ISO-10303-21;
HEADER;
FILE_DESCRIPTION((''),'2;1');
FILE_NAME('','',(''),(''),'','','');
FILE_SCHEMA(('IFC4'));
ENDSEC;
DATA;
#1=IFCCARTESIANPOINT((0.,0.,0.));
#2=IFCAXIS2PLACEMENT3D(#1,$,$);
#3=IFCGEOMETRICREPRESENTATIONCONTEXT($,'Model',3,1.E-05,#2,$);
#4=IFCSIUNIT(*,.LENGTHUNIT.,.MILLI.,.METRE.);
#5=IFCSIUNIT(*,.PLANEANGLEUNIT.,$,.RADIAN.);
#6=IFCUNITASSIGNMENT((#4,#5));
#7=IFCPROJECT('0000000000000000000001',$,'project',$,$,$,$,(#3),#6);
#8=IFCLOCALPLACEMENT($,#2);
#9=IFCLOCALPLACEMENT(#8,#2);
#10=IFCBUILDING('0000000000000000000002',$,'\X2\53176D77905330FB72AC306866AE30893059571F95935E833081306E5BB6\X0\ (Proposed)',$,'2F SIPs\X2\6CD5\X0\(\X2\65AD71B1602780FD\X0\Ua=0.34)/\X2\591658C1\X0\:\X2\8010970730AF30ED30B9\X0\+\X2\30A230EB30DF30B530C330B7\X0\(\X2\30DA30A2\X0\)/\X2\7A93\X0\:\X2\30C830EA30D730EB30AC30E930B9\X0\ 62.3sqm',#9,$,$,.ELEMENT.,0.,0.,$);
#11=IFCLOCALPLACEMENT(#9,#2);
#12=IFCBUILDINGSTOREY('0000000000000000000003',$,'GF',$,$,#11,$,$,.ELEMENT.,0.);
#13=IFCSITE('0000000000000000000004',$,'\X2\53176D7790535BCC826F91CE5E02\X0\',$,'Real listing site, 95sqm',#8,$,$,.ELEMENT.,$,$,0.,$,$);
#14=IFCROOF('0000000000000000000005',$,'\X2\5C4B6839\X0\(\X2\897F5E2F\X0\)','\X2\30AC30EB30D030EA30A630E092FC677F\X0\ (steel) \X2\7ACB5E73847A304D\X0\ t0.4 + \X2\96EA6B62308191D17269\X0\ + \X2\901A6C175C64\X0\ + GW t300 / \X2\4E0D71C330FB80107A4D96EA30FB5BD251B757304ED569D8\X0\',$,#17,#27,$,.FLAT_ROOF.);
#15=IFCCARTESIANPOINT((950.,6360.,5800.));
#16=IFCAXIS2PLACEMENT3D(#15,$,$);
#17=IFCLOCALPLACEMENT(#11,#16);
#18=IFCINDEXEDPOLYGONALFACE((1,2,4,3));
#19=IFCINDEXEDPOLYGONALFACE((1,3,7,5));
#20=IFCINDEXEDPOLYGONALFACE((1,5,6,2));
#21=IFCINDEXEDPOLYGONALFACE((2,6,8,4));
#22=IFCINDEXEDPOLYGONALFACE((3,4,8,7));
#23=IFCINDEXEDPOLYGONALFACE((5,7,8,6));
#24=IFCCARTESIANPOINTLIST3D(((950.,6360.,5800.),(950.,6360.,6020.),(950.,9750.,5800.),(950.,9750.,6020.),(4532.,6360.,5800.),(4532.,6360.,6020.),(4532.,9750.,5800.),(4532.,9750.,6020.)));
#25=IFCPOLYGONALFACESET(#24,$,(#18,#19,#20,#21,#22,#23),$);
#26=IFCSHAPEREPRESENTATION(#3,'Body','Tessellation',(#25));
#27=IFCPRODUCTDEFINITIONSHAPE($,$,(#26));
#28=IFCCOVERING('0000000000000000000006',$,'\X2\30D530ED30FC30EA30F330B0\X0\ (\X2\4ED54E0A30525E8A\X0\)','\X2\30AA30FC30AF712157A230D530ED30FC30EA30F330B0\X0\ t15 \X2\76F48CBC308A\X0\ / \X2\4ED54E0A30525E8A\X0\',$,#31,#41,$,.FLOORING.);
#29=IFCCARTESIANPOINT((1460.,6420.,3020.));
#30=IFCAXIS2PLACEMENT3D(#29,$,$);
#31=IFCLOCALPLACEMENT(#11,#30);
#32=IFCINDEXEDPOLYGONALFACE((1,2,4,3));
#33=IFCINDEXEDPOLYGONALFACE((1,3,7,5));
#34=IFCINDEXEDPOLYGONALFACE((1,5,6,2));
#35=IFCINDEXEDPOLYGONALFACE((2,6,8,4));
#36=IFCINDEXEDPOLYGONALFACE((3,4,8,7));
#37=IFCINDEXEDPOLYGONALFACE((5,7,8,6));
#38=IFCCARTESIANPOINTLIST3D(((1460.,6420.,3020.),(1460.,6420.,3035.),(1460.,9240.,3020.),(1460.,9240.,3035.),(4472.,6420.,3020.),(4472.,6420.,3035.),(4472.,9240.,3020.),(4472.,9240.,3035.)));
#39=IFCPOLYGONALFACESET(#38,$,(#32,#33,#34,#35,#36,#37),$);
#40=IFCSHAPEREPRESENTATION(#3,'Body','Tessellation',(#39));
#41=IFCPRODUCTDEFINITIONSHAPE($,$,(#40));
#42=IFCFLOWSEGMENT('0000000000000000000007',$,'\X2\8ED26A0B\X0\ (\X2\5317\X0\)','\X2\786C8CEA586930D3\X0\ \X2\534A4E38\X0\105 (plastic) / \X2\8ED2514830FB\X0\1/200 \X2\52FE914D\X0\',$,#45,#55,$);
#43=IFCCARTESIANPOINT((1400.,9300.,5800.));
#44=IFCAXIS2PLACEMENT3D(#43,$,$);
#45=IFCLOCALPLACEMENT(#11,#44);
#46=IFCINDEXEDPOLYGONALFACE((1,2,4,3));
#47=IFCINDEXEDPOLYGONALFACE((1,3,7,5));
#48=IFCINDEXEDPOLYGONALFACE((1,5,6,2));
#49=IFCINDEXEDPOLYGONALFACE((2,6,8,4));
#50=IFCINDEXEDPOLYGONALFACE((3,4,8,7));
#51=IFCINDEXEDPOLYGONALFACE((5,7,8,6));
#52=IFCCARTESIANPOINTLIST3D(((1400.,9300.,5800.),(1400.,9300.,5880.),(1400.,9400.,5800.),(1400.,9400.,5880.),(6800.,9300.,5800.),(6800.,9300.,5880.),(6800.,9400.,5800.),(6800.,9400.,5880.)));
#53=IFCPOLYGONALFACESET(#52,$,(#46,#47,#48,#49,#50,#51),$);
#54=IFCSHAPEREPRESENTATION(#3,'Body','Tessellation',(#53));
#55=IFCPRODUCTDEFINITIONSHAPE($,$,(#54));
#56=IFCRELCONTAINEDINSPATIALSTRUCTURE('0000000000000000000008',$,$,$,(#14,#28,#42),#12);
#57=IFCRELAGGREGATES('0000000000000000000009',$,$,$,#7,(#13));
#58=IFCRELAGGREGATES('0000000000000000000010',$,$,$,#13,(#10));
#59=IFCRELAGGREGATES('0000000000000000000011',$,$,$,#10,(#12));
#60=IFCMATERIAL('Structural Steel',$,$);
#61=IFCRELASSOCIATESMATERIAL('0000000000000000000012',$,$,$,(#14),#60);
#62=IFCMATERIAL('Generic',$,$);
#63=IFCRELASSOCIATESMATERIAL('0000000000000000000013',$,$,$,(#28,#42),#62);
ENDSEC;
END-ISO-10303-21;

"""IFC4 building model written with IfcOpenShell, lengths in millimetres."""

from ifc_helpers import new_model, si_unit, frame, frame_2d, origin, place, context, project, spatial, rectangle, extrude, material, element, save


model = new_model("IFC4")

# Units and contexts
model_context = context("Model", 3, precision=1e-05, world=origin())
ifc_project = project(units=[si_unit("LENGTHUNIT", "METRE", prefix="MILLI"), si_unit("PLANEANGLEUNIT", "RADIAN")], contexts=[model_context])

# Site, building, storey
site_placement = place(None, origin())
site = spatial("IfcSite", under=ifc_project, at=site_placement, Name="北海道富良野市", ObjectType="Real listing site, 95sqm", CompositionType="ELEMENT", RefElevation=0.0)
building_placement = place(site_placement, origin())
building = spatial("IfcBuilding", under=site, at=building_placement, Name="北海道・犬と暮らす土間広めの家 (Proposed)", ObjectType="2F SIPs法(断熱性能Ua=0.34)/外壁:耐震クロス+アルミサッシ(ペア)/窓:トリプルガラス 62.3sqm", CompositionType="ELEMENT", ElevationOfRefHeight=0.0, ElevationOfTerrain=0.0)
storey_placement = place(building_placement, origin())
storey = spatial("IfcBuildingStorey", under=building, at=storey_placement, Name="GF", CompositionType="ELEMENT", Elevation=0.0)

# Roof
ifc_material_1 = material(Name="Structural Steel")
for number, where, name in (
    (1, (950.0, 6360.0, 5800.0), "屋根(西帯)"),
):
    element("IfcRoof", number, at=place(storey_placement, frame(where)), inside=storey, material=ifc_material_1, Name=name, Description="ガルバリウム鋼板 (steel) 立平葺き t0.4 + 雪止め金物 + 通気層 + GW t300 / 不燃・耐積雪・寒冷地仕様", PredefinedType="FLAT_ROOF", context=model_context, shape_type="SweptSolid", body=[
        extrude(rectangle(XDim=3582.0, YDim=3390.0, at=frame_2d((1791.0, 1695.0))), frame((950.0, 6360.0, 5800.0)), (0.0, 0.0, 1.0), 220.0),
    ])

# Covering
ifc_material_2 = material(Name="Generic")
covering_placement = place(storey_placement, frame((1460.0, 6420.0, 3020.0)))
element("IfcCovering", 2, at=covering_placement, inside=storey, material=ifc_material_2, Name="フローリング (仕上げ床)", Description="オーク無垢フローリング t15 直貼り / 仕上げ床", PredefinedType="FLOORING", context=model_context, shape_type="SweptSolid", body=[
    extrude(rectangle(XDim=3012.0, YDim=2820.0, at=frame_2d((1506.0, 1410.0))), frame((1460.0, 6420.0, 3020.0)), (0.0, 0.0, 1.0), 15.0),
])

# Flow segment
flow_segment_placement = place(storey_placement, frame((1400.0, 9300.0, 5800.0)))
element("IfcFlowSegment", 3, at=flow_segment_placement, inside=storey, material=ifc_material_2, Name="軒樋 (北)", Description="硬質塩ビ 半丸105 (plastic) / 軒先・1/200 勾配", context=model_context, shape_type="SweptSolid", body=[
    extrude(rectangle(XDim=5400.0, YDim=100.0, at=frame_2d((2700.0, 50.0))), frame((1400.0, 9300.0, 5800.0)), (0.0, 0.0, 1.0), 80.0),
])

save(model, "model.ifc")
